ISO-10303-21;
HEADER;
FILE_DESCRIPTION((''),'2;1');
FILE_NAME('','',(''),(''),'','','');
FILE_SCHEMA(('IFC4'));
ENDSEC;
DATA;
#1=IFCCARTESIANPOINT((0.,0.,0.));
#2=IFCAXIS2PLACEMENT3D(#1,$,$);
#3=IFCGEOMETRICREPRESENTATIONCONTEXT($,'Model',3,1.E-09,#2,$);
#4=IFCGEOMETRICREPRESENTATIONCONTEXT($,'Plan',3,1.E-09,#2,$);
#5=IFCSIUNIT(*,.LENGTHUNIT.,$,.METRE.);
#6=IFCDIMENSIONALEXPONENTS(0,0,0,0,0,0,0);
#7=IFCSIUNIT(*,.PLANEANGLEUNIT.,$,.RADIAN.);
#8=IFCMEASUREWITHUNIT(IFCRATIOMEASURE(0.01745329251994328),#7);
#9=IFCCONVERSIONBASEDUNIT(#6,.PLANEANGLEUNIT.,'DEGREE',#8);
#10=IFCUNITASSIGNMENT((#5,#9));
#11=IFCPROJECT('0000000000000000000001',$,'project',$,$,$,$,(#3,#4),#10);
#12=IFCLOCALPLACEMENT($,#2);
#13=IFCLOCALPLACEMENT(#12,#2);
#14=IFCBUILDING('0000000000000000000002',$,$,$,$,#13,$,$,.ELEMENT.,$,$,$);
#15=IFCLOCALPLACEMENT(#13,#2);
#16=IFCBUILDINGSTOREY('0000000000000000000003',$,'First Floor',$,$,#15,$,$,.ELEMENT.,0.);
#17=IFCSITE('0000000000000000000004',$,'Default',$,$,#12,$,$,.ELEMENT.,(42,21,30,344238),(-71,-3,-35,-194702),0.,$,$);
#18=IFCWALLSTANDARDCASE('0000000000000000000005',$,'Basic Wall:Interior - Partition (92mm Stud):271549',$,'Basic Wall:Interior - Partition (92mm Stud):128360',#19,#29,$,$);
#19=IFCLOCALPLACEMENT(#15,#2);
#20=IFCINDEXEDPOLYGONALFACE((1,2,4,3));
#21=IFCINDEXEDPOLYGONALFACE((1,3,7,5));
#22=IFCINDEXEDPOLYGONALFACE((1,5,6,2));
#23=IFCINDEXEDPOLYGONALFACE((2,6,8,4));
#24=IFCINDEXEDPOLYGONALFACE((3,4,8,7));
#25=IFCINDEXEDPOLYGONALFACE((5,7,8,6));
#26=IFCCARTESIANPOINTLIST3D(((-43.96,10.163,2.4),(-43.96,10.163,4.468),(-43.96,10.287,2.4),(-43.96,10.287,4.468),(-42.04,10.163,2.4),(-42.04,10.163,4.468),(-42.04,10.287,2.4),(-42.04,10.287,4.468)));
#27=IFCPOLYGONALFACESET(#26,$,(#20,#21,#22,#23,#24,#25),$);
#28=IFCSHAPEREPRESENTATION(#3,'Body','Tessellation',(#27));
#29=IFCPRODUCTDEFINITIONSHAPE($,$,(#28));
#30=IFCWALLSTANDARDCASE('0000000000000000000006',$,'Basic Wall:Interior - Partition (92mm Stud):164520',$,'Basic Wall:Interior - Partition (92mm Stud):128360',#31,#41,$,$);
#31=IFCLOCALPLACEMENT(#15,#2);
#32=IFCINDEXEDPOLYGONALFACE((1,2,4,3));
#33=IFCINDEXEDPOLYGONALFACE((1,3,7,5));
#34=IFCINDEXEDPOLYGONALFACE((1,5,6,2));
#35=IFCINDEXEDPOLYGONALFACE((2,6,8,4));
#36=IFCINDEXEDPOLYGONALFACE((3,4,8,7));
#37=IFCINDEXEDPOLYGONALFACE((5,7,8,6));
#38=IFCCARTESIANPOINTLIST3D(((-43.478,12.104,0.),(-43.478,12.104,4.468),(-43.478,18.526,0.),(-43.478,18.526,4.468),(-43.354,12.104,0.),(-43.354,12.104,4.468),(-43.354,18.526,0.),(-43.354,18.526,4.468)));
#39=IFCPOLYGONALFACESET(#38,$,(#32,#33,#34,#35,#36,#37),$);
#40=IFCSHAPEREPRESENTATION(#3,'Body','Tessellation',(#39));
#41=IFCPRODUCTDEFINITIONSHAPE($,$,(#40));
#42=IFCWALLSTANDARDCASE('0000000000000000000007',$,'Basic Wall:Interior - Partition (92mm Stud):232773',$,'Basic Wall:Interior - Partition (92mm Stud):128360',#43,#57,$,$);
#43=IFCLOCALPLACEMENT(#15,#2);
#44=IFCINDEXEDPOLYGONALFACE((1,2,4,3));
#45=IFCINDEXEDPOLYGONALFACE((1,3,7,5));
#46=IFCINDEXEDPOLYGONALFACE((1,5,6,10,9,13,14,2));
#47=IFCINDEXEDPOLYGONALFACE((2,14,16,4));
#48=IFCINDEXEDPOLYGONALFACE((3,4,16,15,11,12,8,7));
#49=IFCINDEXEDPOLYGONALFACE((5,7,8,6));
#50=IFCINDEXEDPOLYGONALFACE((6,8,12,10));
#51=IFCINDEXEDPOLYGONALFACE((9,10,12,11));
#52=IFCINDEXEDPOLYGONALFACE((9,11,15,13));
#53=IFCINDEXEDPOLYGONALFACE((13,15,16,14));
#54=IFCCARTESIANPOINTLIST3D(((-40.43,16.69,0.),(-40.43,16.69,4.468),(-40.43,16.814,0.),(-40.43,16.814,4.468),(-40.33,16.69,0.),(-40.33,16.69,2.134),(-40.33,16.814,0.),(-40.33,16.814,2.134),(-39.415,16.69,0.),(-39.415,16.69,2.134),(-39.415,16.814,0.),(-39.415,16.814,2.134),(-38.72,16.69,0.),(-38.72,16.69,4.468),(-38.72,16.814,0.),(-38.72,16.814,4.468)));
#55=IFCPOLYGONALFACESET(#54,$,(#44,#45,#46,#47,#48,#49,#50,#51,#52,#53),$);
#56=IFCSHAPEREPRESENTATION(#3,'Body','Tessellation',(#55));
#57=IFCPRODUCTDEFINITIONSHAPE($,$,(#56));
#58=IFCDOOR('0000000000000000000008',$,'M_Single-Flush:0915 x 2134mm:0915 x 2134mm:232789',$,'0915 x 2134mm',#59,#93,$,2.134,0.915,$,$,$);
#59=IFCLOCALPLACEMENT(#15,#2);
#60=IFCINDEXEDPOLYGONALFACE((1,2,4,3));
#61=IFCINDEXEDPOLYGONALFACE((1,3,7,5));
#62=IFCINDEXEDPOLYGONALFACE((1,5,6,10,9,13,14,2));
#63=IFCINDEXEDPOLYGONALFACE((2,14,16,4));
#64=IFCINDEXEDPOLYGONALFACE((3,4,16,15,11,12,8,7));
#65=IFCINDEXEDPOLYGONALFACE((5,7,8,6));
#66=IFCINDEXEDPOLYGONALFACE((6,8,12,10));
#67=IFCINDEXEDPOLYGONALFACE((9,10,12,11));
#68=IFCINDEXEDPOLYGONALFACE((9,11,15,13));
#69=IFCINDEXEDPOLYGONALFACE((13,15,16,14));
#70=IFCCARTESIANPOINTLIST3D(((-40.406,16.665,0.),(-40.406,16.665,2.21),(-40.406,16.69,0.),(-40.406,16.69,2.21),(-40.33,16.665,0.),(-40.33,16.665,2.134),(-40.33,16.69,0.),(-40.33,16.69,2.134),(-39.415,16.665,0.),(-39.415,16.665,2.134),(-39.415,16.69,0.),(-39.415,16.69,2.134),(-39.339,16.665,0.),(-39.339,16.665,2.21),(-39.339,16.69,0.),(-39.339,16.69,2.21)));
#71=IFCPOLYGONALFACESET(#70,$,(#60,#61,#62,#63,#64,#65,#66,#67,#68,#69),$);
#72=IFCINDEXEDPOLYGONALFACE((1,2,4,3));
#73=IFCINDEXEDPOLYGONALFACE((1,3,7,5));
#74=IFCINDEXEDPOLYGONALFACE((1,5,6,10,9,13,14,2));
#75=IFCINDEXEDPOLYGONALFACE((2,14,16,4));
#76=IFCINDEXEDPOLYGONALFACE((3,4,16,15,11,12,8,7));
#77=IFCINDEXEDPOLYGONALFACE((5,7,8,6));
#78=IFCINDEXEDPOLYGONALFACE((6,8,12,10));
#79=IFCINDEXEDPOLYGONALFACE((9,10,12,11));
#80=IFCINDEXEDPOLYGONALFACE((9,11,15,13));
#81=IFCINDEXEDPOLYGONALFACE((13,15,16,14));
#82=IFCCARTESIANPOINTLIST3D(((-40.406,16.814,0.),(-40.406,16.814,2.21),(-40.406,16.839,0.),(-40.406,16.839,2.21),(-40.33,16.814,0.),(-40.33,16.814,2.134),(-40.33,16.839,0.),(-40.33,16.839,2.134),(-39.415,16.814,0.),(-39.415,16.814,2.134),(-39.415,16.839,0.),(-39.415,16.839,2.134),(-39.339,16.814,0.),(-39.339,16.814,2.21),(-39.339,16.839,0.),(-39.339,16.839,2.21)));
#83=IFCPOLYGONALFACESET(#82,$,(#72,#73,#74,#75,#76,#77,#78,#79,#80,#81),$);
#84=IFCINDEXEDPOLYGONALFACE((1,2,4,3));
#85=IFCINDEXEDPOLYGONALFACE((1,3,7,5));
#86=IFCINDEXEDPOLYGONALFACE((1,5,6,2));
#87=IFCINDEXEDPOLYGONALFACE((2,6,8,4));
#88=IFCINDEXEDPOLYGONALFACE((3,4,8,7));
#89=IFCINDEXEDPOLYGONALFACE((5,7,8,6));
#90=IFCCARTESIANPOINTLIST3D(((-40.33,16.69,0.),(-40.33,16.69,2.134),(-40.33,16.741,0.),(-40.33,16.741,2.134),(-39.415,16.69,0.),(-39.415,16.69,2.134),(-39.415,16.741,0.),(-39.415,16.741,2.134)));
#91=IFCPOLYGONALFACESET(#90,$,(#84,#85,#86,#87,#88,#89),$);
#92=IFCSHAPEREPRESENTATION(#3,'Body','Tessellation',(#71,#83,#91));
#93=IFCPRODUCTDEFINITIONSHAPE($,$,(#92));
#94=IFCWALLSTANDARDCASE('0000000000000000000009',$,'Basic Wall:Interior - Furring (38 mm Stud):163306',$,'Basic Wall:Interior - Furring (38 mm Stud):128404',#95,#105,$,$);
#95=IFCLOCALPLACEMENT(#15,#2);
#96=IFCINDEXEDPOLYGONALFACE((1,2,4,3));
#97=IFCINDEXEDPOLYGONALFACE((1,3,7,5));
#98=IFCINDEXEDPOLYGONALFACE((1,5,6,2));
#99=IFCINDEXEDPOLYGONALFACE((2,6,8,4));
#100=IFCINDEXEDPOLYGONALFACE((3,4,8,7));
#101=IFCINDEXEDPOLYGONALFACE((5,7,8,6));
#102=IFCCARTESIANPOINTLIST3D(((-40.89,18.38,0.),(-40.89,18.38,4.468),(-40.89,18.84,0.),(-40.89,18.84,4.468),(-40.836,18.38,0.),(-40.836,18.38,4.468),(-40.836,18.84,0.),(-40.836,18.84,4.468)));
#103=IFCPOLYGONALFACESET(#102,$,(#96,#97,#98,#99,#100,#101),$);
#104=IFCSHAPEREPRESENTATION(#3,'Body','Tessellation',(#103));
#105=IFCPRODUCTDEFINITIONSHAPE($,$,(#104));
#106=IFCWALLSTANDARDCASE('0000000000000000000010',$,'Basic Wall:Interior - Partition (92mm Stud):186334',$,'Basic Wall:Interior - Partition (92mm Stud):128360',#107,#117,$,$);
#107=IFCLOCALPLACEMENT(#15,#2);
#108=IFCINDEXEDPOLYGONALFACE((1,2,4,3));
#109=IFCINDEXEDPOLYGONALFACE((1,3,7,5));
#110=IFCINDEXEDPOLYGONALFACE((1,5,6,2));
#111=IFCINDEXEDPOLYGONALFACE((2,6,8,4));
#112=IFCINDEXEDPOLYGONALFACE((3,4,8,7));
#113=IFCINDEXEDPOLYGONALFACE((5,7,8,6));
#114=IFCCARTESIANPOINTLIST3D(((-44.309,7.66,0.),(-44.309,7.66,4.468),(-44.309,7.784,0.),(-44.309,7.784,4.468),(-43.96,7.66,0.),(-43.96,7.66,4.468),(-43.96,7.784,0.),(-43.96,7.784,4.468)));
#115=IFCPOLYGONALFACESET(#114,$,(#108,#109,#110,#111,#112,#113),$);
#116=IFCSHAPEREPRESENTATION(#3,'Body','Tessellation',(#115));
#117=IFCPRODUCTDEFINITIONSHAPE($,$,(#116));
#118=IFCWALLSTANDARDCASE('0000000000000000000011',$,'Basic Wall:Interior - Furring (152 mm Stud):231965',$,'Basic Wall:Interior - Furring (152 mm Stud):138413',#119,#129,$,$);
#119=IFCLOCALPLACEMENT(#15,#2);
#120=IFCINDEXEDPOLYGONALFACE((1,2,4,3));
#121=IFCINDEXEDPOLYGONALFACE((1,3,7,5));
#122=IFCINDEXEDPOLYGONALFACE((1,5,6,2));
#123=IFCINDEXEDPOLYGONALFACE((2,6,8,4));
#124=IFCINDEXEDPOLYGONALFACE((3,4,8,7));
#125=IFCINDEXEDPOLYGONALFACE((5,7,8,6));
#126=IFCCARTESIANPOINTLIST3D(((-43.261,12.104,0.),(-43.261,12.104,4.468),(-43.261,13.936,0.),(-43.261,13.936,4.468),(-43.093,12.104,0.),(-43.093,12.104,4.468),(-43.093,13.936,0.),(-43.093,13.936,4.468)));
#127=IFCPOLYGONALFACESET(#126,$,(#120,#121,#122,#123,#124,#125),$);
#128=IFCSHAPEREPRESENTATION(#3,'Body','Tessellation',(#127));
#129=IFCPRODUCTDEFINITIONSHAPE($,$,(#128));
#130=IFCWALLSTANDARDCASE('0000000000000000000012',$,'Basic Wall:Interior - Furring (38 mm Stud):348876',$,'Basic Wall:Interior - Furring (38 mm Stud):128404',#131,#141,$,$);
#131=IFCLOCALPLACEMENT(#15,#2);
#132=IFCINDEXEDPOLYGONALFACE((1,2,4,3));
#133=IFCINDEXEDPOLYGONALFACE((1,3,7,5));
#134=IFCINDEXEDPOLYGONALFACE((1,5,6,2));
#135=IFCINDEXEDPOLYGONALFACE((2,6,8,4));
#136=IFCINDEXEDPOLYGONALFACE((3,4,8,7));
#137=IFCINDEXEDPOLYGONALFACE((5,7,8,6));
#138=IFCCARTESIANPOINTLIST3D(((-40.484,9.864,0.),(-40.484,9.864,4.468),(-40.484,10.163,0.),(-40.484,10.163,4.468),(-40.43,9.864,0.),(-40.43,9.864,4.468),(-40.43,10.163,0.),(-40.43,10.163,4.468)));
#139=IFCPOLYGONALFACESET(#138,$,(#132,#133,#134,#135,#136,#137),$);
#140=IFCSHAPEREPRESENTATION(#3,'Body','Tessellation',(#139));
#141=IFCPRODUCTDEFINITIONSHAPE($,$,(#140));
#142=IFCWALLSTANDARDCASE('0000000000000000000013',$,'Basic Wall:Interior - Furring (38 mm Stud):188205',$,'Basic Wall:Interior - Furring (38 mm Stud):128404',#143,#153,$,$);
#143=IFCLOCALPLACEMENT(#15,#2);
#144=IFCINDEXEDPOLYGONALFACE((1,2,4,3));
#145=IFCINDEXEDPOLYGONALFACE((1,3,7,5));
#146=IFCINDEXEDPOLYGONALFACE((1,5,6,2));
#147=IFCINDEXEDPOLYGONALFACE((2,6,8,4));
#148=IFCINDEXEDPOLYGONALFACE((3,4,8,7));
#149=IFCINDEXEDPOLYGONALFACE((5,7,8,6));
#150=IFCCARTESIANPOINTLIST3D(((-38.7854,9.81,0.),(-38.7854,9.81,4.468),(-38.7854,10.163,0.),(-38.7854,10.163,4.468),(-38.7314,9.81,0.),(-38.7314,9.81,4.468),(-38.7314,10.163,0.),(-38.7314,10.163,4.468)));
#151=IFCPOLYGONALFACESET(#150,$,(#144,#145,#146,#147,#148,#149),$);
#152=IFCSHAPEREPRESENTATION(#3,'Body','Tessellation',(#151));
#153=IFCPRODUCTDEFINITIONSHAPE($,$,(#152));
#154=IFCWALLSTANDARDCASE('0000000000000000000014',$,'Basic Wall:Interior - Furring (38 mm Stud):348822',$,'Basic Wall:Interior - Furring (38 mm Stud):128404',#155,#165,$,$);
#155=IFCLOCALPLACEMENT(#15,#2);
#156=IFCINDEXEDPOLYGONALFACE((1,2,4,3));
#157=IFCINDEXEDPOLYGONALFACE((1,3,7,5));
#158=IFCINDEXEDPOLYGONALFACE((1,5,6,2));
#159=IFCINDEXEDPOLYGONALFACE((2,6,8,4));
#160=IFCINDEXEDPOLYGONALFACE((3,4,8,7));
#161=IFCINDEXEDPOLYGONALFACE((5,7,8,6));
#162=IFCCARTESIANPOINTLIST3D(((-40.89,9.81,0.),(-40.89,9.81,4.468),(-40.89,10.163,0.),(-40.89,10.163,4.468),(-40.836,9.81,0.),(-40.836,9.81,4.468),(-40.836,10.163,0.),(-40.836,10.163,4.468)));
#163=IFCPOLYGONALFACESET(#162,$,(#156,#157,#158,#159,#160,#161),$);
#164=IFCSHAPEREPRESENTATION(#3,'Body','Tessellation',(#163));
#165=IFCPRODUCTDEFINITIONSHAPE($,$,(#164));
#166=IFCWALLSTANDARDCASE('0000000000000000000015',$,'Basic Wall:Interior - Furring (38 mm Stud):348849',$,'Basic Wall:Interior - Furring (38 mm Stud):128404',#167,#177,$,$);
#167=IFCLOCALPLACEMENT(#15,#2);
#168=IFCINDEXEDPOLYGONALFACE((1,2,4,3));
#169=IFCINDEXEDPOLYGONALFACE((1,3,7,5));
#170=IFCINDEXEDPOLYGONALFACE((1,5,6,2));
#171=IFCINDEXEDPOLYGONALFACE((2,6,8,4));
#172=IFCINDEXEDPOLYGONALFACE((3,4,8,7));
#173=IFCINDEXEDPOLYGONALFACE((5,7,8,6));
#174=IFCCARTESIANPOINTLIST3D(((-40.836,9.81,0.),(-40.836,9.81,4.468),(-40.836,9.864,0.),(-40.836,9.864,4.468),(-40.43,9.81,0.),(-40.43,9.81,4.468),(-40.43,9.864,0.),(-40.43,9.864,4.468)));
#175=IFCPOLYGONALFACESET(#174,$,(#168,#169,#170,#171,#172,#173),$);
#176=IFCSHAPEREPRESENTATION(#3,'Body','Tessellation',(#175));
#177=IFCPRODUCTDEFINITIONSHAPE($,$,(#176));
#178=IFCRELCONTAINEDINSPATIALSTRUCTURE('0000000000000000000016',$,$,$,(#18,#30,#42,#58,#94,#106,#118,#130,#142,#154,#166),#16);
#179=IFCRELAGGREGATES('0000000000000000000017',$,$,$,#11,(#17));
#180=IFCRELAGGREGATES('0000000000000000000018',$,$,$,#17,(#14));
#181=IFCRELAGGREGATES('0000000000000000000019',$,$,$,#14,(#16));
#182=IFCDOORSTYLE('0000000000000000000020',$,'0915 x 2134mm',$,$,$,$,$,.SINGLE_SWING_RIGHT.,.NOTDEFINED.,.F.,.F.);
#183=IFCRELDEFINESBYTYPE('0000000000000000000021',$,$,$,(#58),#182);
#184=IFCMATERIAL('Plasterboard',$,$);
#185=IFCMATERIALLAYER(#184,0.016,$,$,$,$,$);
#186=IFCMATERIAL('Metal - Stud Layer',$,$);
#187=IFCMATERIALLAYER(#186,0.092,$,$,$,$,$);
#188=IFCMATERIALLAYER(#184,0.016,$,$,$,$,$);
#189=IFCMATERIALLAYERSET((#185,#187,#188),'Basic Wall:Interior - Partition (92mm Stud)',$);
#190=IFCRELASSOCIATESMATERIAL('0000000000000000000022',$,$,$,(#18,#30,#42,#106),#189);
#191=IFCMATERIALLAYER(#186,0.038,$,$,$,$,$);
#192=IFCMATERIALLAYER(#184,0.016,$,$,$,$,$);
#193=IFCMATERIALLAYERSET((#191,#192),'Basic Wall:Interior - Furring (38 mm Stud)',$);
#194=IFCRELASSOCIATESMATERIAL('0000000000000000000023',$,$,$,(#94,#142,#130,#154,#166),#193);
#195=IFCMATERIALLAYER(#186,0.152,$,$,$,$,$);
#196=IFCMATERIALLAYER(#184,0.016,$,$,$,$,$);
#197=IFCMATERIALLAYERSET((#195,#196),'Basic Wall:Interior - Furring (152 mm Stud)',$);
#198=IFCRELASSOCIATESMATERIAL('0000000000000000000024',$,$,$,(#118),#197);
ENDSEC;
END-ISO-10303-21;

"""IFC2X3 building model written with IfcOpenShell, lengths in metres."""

from ifc_helpers import new_model, entity, si_unit, converted_unit, frame, frame_2d, origin, origin_2d_with_axis, place, context, project, spatial, polyline, rectangle, outline, extrude, source, transform, mapped, material, layer, layer_set, layer_usage, type_object, type_shapes, element, fill, save


model = new_model("IFC2X3")

# Units and contexts
model_context = context("Model", 3, precision=1e-09, world=origin())
plan_context = context("Plan", 3, precision=1e-09, world=origin())
ifc_project = project(units=[si_unit("LENGTHUNIT", "METRE"), converted_unit("PLANEANGLEUNIT", "DEGREE", entity("IfcRatioMeasure", 0.01745329251994328), si_unit("PLANEANGLEUNIT", "RADIAN"), dimensions=[0, 0, 0, 0, 0, 0, 0])], contexts=[model_context, plan_context])

# Site, building, storey
site_placement = place(None, origin())
site = spatial("IfcSite", under=ifc_project, at=site_placement, Name="Default", CompositionType="ELEMENT", RefLatitude=(42, 21, 30, 344238), RefLongitude=(-71, -3, -35, -194702), RefElevation=0.0)
building_placement = place(site_placement, origin())
building = spatial("IfcBuilding", under=site, at=building_placement, CompositionType="ELEMENT")
storey_placement = place(building_placement, origin())
storey = spatial("IfcBuildingStorey", under=building, at=storey_placement, Name="First Floor", CompositionType="ELEMENT", Elevation=0.0)

# Shared definitions
ifc_material_1 = material(Name="Plasterboard")
ifc_layer_1 = layer(ifc_material_1, 0.016)
ifc_material_2 = material(Name="Metal - Stud Layer")
ifc_layer_2 = layer(ifc_material_2, 0.092)
ifc_layer_3 = layer(ifc_material_1, 0.016)
ifc_layer_set_1 = layer_set([ifc_layer_1, ifc_layer_2, ifc_layer_3], Name="Basic Wall:Interior - Partition (92mm Stud)")
ifc_layer_usage_1 = layer_usage(ifc_layer_set_1, "AXIS2", "NEGATIVE", 0.062)
door_style_1 = type_object("IfcDoorStyle", Name="0915 x 2134mm", ConstructionType="NOTDEFINED", OperationType="SINGLE_SWING_RIGHT", ParameterTakesPrecedence=False, Sizeable=False)
shared_shape_1 = source(origin(), model_context, "Body", "SweptSolid", [
    extrude(outline(polyline([(-0.5335, -1.124), (0.5335, -1.124), (0.5335, 1.086), (0.4575, 1.086), (0.4575, -1.048), (-0.4575, -1.048), (-0.4575, 1.086), (-0.5335, 1.086), (-0.5335, -1.124)])), frame((0.4575, 0.124, 1.086), z_axis=(0.0, 1.0, 0.0), x_axis=(1.0, 0.0, 0.0)), (0.0, 0.0, 1.0), 0.025),
    extrude(outline(polyline([(-1.124, -0.5335), (1.086, -0.5335), (1.086, -0.4575), (-1.048, -0.4575), (-1.048, 0.4575), (1.086, 0.4575), (1.086, 0.5335), (-1.124, 0.5335), (-1.124, -0.5335)])), frame((0.4575, -0.025, 1.086), z_axis=(0.0, 1.0, 0.0), x_axis=(0.0, 0.0, -1.0)), (0.0, 0.0, 1.0), 0.025),
    extrude(rectangle(XDim=0.051, YDim=0.915, at=origin_2d_with_axis()), frame((0.4575, 0.0985, 0.0), z_axis=(0.0, 0.0, 1.0), x_axis=(0.0, 1.0, 0.0)), (0.0, 0.0, 1.0), 2.134),
])
type_shapes(door_style_1, [shared_shape_1])

# Walls
wall_1_placement = place(storey_placement, frame((-43.96, 10.225, 2.4)))
element("IfcWallStandardCase", 1, at=wall_1_placement, inside=storey, material=ifc_layer_usage_1, Name="Basic Wall:Interior - Partition (92mm Stud):271549", ObjectType="Basic Wall:Interior - Partition (92mm Stud):128360", context=model_context, shape_type="SweptSolid", body=[
    extrude(rectangle(XDim=1.92, YDim=0.124, at=frame_2d((0.96, 0.0), x_axis=(-1.0, 0.0))), origin(), (0.0, 0.0, 1.0), 2.068),
])
wall_2_placement = place(storey_placement, frame((-43.416, 12.104, 0.0), z_axis=(0.0, 0.0, 1.0), x_axis=(0.0, 1.0, 0.0)))
element("IfcWallStandardCase", 2, at=wall_2_placement, inside=storey, material=ifc_layer_usage_1, Name="Basic Wall:Interior - Partition (92mm Stud):164520", ObjectType="Basic Wall:Interior - Partition (92mm Stud):128360", context=model_context, shape_type="SweptSolid", body=[
    extrude(rectangle(XDim=6.422, YDim=0.124, at=frame_2d((3.211, 0.0), x_axis=(-1.0, 0.0))), origin(), (0.0, 0.0, 1.0), 4.468),
])

# Wall, opening, door
wall_3_placement = place(storey_placement, frame((-38.72, 16.752, 0.0), z_axis=(0.0, 0.0, 1.0), x_axis=(-1.0, 0.0, 0.0)))
wall_3 = element("IfcWallStandardCase", 3, at=wall_3_placement, inside=storey, material=ifc_layer_usage_1, Name="Basic Wall:Interior - Partition (92mm Stud):232773", ObjectType="Basic Wall:Interior - Partition (92mm Stud):128360", context=model_context, shape_type="SweptSolid", body=[
    extrude(rectangle(XDim=1.71, YDim=0.124, at=frame_2d((0.855, 0.0), x_axis=(-1.0, 0.0))), origin(), (0.0, 0.0, 1.0), 4.468),
])
opening_1_placement = place(wall_3_placement, frame((0.695, -0.062, 0.0)))
opening_1 = element("IfcOpeningElement", 4, at=opening_1_placement, cuts=wall_3, ObjectType="Opening", context=model_context, shape_type="SweptSolid", body=[
    extrude(rectangle(XDim=0.915, YDim=2.134, at=frame_2d((1.067, 0.4575), x_axis=(0.0, 1.0))), frame((0.0, 0.0, 0.0), z_axis=(0.0, 1.0, 0.0), x_axis=(0.0, 0.0, 1.0)), (0.0, 0.0, 1.0), 0.124),
])
door_1_placement = place(opening_1_placement, origin())
door_1 = element("IfcDoor", 5, at=door_1_placement, inside=storey, type_object=door_style_1, Name="M_Single-Flush:0915 x 2134mm:0915 x 2134mm:232789", ObjectType="0915 x 2134mm", OverallHeight=2.134, OverallWidth=0.915, context=model_context, shape_type="MappedRepresentation", body=[
    mapped(shared_shape_1, transform((0.0, 0.0, 0.0), scale=1.0)),
])
fill(opening_1, door_1)

# Walls
ifc_layer_4 = layer(ifc_material_2, 0.038)
ifc_layer_5 = layer(ifc_material_1, 0.016)
ifc_layer_set_2 = layer_set([ifc_layer_4, ifc_layer_5], Name="Basic Wall:Interior - Furring (38 mm Stud)")
ifc_layer_usage_2 = layer_usage(ifc_layer_set_2, "AXIS2", "POSITIVE", -0.027)
wall_4_placement = place(storey_placement, frame((-40.863, 18.38, 0.0), z_axis=(0.0, 0.0, 1.0), x_axis=(0.0, 1.0, 0.0)))
element("IfcWallStandardCase", 6, at=wall_4_placement, inside=storey, material=ifc_layer_usage_2, Name="Basic Wall:Interior - Furring (38 mm Stud):163306", ObjectType="Basic Wall:Interior - Furring (38 mm Stud):128404", context=model_context, shape_type="SweptSolid", body=[
    extrude(rectangle(XDim=0.46, YDim=0.054, at=frame_2d((0.23, 0.0), x_axis=(-1.0, 0.0))), origin(), (0.0, 0.0, 1.0), 4.468),
])
wall_5_placement = place(storey_placement, frame((-43.96, 7.722, 0.0), z_axis=(0.0, 0.0, 1.0), x_axis=(-1.0, 0.0, 0.0)))
element("IfcWallStandardCase", 7, at=wall_5_placement, inside=storey, material=ifc_layer_usage_1, Name="Basic Wall:Interior - Partition (92mm Stud):186334", ObjectType="Basic Wall:Interior - Partition (92mm Stud):128360", context=model_context, shape_type="SweptSolid", body=[
    extrude(rectangle(XDim=0.349, YDim=0.124, at=frame_2d((0.1745, 0.0), x_axis=(-1.0, 0.0))), origin(), (0.0, 0.0, 1.0), 4.468),
])
ifc_layer_6 = layer(ifc_material_2, 0.152)
ifc_layer_7 = layer(ifc_material_1, 0.016)
ifc_layer_set_3 = layer_set([ifc_layer_6, ifc_layer_7], Name="Basic Wall:Interior - Furring (152 mm Stud)")
ifc_layer_usage_3 = layer_usage(ifc_layer_set_3, "AXIS2", "POSITIVE", -0.084)
wall_6_placement = place(storey_placement, frame((-43.177, 13.936, 0.0), z_axis=(0.0, 0.0, 1.0), x_axis=(0.0, -1.0, 0.0)))
element("IfcWallStandardCase", 8, at=wall_6_placement, inside=storey, material=ifc_layer_usage_3, Name="Basic Wall:Interior - Furring (152 mm Stud):231965", ObjectType="Basic Wall:Interior - Furring (152 mm Stud):138413", context=model_context, shape_type="SweptSolid", body=[
    extrude(rectangle(XDim=1.832, YDim=0.168, at=frame_2d((0.916, 0.0), x_axis=(-1.0, 0.0))), origin(), (0.0, 0.0, 1.0), 4.468),
])
ifc_layer_usage_4 = layer_usage(ifc_layer_set_2, "AXIS2", "NEGATIVE", 0.027)
wall_7_placement = place(storey_placement, frame((-40.457, 9.864, 0.0), z_axis=(0.0, 0.0, 1.0), x_axis=(0.0, 1.0, 0.0)))
element("IfcWallStandardCase", 9, at=wall_7_placement, inside=storey, material=ifc_layer_usage_4, Name="Basic Wall:Interior - Furring (38 mm Stud):348876", ObjectType="Basic Wall:Interior - Furring (38 mm Stud):128404", context=model_context, shape_type="SweptSolid", body=[
    extrude(rectangle(XDim=0.299, YDim=0.054, at=frame_2d((0.1495, 0.0), x_axis=(-1.0, 0.0))), origin(), (0.0, 0.0, 1.0), 4.468),
])
wall_8_placement = place(storey_placement, frame((-38.7584, 9.81, 0.0), z_axis=(0.0, 0.0, 1.0), x_axis=(0.0, 1.0, 0.0)))
element("IfcWallStandardCase", 10, at=wall_8_placement, inside=storey, material=ifc_layer_usage_2, Name="Basic Wall:Interior - Furring (38 mm Stud):188205", ObjectType="Basic Wall:Interior - Furring (38 mm Stud):128404", context=model_context, shape_type="SweptSolid", body=[
    extrude(rectangle(XDim=0.353, YDim=0.054, at=frame_2d((0.1765, 0.0), x_axis=(-1.0, 0.0))), origin(), (0.0, 0.0, 1.0), 4.468),
])
wall_9_placement = place(storey_placement, frame((-40.863, 10.163, 0.0), z_axis=(0.0, 0.0, 1.0), x_axis=(0.0, -1.0, 0.0)))
element("IfcWallStandardCase", 11, at=wall_9_placement, inside=storey, material=ifc_layer_usage_4, Name="Basic Wall:Interior - Furring (38 mm Stud):348822", ObjectType="Basic Wall:Interior - Furring (38 mm Stud):128404", context=model_context, shape_type="SweptSolid", body=[
    extrude(rectangle(XDim=0.353, YDim=0.054, at=frame_2d((0.1765, 0.0), x_axis=(-1.0, 0.0))), origin(), (0.0, 0.0, 1.0), 4.468),
])
wall_10_placement = place(storey_placement, frame((-40.836, 9.837, 0.0)))
element("IfcWallStandardCase", 12, at=wall_10_placement, inside=storey, material=ifc_layer_usage_4, Name="Basic Wall:Interior - Furring (38 mm Stud):348849", ObjectType="Basic Wall:Interior - Furring (38 mm Stud):128404", context=model_context, shape_type="SweptSolid", body=[
    extrude(rectangle(XDim=0.406, YDim=0.054, at=frame_2d((0.203, 0.0), x_axis=(-1.0, 0.0))), origin(), (0.0, 0.0, 1.0), 4.468),
])

save(model, "model.ifc")
